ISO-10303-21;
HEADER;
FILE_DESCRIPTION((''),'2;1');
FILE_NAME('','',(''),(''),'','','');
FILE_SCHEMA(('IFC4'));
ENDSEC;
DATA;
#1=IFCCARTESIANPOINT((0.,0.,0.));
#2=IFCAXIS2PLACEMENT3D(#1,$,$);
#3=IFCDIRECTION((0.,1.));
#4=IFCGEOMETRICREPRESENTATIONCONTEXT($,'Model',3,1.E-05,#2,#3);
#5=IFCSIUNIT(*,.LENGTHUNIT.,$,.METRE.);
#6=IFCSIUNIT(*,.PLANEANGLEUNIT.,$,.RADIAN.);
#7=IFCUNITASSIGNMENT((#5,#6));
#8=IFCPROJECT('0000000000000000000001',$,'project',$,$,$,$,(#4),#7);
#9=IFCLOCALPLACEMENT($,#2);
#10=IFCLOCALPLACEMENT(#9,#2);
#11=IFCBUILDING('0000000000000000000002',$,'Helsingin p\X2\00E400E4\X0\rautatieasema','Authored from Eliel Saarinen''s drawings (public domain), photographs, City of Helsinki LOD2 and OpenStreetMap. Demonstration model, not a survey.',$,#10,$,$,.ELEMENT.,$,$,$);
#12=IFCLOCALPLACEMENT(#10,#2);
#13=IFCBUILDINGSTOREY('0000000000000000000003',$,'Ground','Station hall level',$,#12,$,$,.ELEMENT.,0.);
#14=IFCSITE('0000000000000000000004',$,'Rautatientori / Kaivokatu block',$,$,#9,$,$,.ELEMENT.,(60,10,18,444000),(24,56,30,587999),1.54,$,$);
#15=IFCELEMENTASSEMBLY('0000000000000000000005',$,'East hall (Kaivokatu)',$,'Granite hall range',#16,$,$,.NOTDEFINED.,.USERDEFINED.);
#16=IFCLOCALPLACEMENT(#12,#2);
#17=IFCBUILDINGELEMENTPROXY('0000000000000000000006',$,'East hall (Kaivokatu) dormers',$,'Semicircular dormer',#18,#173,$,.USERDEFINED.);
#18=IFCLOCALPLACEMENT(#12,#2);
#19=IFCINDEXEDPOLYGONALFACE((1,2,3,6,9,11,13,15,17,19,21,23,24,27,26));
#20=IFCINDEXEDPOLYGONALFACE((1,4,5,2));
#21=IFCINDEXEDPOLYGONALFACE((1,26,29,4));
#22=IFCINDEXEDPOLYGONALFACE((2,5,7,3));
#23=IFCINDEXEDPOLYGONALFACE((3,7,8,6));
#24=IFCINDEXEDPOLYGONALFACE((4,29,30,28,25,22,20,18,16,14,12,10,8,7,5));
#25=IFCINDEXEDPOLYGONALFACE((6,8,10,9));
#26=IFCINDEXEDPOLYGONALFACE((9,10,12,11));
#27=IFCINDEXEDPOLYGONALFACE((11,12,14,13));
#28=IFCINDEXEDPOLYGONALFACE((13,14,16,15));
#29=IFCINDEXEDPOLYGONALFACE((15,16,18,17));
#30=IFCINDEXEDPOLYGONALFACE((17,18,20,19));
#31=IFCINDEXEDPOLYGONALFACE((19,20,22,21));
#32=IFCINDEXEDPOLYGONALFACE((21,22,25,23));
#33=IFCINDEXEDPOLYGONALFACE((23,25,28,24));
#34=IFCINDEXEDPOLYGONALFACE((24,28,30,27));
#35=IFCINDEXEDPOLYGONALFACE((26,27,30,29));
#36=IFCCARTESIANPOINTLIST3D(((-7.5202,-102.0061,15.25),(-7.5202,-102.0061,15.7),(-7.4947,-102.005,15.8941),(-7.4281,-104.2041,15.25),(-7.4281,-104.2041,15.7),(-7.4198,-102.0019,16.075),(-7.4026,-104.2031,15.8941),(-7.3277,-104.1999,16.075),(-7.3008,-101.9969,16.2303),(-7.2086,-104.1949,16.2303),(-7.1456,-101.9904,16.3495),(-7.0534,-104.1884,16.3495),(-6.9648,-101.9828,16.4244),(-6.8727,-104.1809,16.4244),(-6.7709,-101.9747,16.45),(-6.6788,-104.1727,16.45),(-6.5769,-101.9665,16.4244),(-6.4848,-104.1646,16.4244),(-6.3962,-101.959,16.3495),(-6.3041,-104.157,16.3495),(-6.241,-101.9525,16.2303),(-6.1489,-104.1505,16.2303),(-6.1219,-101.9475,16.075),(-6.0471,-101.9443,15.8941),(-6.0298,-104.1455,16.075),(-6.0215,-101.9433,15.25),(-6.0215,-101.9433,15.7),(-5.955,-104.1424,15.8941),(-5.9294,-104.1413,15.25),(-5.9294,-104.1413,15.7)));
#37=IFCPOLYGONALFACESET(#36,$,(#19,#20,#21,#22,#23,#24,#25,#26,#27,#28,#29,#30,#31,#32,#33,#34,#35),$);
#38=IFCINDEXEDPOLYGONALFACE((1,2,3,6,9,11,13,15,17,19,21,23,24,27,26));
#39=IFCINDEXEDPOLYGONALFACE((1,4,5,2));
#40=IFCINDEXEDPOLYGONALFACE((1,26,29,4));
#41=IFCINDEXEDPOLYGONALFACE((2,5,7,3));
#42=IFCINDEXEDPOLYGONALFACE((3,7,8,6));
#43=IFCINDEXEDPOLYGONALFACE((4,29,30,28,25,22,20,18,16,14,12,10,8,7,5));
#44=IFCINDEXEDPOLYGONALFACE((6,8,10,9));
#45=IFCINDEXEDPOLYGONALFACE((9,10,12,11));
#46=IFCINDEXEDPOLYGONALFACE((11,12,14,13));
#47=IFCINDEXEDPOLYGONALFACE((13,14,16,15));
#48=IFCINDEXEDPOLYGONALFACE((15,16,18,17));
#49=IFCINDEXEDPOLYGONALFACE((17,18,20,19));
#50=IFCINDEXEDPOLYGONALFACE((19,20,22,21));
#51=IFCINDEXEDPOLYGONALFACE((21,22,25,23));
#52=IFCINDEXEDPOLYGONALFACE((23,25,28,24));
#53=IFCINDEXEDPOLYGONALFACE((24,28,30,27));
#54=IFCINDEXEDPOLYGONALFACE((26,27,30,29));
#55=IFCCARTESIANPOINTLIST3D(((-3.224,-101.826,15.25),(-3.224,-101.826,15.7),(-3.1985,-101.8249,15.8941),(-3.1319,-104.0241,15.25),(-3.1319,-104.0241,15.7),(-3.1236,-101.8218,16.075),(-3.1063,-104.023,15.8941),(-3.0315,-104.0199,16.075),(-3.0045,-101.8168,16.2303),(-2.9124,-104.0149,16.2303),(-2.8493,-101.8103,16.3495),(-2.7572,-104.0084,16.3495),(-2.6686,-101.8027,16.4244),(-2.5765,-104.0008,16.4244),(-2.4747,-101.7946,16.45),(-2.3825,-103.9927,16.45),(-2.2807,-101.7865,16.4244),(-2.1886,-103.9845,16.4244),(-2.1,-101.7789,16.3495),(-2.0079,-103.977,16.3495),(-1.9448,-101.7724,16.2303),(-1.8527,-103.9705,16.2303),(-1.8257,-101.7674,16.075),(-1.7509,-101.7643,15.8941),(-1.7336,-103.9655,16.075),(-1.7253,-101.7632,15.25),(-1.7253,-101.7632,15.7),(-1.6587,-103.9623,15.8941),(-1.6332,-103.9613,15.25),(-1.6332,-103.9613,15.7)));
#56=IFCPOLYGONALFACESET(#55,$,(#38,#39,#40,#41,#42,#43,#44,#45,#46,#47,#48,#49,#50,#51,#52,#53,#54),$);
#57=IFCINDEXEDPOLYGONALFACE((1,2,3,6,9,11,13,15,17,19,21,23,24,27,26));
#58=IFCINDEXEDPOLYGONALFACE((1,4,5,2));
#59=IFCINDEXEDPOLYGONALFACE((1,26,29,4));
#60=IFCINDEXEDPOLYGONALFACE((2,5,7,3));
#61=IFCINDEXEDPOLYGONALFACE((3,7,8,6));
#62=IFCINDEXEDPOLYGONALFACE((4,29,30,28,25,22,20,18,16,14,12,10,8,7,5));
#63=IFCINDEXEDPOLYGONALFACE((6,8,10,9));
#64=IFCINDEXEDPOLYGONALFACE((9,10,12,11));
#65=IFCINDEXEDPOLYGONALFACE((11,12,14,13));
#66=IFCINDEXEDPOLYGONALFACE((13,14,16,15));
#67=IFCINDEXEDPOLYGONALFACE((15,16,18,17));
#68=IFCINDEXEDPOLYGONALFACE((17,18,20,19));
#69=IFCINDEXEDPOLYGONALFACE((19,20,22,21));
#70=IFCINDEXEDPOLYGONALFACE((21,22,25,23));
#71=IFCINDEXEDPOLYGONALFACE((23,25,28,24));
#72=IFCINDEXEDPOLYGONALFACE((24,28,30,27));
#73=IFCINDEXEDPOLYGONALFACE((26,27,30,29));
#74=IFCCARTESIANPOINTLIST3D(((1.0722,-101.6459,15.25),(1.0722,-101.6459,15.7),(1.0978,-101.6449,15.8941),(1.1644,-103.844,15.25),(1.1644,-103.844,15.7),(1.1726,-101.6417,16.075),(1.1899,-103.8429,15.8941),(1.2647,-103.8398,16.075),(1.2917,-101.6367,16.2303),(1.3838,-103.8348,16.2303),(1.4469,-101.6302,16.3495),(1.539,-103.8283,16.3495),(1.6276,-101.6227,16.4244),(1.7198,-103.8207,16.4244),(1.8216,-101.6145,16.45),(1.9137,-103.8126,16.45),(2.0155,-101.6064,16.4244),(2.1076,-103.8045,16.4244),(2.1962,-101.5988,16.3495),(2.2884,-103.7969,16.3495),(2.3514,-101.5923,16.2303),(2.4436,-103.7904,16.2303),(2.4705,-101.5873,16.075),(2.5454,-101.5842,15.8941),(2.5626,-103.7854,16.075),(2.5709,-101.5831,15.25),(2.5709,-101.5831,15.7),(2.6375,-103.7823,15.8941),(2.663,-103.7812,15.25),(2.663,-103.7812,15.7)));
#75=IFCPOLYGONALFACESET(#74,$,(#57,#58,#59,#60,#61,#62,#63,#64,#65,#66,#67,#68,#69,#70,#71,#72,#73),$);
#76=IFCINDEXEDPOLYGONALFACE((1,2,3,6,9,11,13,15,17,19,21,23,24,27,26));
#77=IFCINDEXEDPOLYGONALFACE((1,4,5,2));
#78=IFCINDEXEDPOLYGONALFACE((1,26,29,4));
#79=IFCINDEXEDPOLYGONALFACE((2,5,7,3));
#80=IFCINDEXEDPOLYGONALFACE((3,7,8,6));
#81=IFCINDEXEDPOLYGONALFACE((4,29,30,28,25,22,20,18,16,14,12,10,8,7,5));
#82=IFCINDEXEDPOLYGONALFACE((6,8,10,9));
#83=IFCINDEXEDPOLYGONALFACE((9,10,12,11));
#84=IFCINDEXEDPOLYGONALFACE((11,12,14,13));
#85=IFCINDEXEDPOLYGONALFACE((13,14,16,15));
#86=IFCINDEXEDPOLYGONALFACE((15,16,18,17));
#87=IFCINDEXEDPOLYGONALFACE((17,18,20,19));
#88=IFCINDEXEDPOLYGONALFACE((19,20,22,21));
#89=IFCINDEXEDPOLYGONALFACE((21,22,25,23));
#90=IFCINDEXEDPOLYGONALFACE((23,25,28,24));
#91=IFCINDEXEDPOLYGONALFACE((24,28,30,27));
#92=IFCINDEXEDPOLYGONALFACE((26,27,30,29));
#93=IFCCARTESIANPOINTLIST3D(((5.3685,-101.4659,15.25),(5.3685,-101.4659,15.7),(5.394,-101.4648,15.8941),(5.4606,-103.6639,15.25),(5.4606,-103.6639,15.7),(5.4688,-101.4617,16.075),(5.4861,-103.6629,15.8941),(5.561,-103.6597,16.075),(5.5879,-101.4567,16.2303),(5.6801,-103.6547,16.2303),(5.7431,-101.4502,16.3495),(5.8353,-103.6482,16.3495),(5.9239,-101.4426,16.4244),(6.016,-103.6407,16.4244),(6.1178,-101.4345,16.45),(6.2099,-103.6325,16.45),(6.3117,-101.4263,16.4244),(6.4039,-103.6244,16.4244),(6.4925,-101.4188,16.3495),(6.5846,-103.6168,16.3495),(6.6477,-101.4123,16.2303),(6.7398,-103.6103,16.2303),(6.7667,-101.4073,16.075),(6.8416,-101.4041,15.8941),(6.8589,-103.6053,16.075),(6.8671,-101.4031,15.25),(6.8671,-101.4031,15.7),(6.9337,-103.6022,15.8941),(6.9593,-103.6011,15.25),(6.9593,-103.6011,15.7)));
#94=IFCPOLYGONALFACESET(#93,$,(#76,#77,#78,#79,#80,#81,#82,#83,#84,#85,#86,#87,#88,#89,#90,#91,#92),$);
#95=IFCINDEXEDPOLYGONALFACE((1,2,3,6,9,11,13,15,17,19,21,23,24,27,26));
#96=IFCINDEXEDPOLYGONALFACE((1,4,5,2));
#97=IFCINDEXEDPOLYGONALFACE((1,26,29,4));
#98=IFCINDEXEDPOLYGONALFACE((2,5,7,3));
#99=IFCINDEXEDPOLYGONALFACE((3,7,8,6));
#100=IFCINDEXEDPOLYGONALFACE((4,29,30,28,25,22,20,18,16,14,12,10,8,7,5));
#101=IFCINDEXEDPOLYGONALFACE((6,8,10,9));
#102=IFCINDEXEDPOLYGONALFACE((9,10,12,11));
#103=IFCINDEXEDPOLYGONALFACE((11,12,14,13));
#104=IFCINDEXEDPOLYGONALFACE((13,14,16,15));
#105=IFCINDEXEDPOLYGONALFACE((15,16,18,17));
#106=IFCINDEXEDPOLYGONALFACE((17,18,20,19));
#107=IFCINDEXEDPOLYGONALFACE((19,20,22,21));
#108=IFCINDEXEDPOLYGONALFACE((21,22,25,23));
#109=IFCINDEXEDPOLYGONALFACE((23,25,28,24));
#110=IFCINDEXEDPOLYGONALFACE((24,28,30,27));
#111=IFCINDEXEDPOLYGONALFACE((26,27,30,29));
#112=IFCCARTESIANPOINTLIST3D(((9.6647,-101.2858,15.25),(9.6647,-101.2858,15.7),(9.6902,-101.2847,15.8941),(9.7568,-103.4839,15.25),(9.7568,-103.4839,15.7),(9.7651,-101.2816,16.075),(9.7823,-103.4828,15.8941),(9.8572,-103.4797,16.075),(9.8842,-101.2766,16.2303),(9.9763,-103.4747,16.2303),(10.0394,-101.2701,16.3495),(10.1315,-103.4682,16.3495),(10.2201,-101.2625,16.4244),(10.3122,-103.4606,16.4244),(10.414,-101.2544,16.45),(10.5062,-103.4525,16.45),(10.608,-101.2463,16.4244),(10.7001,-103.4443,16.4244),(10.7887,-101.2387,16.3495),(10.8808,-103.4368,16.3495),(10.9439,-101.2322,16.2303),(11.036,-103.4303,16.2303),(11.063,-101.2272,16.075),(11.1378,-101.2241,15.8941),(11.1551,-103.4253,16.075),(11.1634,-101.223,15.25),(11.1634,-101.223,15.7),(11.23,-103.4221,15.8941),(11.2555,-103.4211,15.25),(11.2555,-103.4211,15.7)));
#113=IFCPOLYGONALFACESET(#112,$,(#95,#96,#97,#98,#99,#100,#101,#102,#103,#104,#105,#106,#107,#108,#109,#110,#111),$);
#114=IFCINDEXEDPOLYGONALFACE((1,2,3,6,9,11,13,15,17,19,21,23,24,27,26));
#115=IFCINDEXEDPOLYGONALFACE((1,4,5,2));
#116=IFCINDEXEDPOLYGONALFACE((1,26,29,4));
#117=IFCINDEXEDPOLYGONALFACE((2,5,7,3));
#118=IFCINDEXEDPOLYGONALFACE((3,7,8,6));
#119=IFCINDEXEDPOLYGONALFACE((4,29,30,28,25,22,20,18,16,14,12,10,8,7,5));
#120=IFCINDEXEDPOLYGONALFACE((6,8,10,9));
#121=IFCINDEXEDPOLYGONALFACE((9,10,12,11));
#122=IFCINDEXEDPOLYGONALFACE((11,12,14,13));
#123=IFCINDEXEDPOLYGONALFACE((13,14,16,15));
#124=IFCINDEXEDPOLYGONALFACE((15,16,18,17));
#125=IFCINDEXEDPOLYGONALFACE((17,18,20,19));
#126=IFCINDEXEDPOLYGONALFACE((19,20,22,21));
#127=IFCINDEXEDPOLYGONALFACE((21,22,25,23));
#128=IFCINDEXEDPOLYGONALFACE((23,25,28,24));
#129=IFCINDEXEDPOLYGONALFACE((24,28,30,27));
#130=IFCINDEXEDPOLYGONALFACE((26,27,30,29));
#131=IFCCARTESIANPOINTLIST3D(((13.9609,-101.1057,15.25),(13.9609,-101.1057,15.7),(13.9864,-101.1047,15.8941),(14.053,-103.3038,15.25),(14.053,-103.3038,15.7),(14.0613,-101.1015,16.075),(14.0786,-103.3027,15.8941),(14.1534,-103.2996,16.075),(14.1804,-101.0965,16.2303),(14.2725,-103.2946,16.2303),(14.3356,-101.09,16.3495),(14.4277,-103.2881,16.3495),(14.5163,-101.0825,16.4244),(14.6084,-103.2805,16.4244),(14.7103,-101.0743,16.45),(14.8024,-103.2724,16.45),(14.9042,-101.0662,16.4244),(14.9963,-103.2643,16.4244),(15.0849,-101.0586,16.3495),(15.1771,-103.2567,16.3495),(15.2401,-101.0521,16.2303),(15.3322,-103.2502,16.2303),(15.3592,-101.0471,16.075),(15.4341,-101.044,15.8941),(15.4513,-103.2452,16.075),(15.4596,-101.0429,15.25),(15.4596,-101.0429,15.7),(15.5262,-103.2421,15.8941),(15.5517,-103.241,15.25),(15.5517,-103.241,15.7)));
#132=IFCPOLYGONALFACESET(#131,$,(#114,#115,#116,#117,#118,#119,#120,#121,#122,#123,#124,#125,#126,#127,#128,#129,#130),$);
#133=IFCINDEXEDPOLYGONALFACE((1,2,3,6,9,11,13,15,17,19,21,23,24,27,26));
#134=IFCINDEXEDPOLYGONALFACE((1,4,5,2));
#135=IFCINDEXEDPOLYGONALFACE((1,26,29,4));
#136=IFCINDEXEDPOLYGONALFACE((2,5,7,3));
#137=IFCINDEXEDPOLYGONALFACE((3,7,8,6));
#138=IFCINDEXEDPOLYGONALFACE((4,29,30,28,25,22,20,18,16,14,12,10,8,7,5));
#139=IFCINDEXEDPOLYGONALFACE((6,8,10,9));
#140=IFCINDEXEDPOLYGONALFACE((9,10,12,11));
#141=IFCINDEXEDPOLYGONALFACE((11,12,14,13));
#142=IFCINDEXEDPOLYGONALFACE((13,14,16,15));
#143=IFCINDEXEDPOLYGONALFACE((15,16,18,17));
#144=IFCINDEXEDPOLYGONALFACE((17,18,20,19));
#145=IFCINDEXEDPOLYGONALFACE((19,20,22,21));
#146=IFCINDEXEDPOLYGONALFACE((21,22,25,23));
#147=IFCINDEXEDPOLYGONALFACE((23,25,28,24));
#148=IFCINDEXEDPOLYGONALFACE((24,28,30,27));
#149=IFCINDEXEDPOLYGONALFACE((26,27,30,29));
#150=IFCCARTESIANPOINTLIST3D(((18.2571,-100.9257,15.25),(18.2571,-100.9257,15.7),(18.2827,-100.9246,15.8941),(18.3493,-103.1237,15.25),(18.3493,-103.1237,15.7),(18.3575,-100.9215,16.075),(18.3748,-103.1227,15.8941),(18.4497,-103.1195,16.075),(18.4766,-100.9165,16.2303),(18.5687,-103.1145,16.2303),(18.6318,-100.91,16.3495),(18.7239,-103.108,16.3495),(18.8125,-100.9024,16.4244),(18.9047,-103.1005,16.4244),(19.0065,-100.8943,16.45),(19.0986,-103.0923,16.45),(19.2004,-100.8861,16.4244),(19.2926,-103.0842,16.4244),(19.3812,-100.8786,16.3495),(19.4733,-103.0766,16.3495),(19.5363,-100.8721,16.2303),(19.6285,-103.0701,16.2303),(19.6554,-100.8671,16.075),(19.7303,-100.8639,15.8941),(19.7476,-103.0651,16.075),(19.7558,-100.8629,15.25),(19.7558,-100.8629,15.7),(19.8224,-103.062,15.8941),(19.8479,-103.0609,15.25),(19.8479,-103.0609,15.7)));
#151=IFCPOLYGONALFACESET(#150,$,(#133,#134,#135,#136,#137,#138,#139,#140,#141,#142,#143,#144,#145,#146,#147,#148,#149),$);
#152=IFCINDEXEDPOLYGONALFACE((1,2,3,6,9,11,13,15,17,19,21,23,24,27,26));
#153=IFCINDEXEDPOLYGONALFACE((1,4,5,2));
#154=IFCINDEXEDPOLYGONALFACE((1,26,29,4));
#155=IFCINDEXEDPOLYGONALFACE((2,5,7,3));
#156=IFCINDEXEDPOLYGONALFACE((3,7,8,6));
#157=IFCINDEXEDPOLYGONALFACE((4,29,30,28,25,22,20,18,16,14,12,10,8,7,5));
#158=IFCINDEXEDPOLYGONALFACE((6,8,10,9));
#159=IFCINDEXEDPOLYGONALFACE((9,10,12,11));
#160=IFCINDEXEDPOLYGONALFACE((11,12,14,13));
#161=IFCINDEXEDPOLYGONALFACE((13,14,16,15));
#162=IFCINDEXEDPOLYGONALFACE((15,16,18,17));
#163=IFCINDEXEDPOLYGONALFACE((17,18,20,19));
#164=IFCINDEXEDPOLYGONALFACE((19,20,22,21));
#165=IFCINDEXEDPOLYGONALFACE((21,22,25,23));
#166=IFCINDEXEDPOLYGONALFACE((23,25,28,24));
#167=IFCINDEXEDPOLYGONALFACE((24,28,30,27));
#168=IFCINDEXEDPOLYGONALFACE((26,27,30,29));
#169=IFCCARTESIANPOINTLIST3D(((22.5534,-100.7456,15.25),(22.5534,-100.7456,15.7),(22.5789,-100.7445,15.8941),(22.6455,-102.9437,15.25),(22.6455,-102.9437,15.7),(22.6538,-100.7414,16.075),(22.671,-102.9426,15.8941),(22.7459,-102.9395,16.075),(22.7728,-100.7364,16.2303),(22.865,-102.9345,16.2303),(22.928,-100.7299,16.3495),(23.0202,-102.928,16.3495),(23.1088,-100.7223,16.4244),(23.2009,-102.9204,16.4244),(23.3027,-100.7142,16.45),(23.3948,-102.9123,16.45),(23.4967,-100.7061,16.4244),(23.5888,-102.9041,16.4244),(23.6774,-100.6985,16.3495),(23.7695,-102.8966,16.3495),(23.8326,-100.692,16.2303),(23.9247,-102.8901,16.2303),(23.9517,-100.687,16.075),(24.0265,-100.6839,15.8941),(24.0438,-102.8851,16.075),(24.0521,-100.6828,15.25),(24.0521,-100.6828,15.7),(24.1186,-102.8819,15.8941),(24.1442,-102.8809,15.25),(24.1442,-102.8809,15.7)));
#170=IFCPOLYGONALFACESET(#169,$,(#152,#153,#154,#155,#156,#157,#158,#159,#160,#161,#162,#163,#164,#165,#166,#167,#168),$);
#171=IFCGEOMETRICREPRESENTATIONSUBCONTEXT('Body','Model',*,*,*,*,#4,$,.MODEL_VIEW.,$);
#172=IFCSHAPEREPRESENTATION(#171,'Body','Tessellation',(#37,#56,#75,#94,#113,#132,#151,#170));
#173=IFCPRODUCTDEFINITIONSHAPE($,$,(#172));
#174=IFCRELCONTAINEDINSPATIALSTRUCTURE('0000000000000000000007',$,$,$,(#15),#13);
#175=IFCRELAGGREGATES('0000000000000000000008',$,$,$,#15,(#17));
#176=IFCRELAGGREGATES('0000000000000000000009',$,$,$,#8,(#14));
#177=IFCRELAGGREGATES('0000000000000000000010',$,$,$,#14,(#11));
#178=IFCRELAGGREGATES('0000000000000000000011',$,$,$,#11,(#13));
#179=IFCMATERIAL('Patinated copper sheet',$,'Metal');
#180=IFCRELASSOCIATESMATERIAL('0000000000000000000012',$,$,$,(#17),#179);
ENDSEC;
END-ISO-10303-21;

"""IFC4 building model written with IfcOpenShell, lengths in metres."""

from ifc_helpers import new_model, si_unit, direction, frame, origin, place, context, subcontext, project, spatial, polyline, outline, extrude, material, element, aggregate, save


model = new_model("IFC4")

# Units and contexts
model_context = context("Model", 3, precision=1e-05, world=origin(), true_north=direction((0.0, 1.0)))
body_context = subcontext(model_context, "Body", "Model", "MODEL_VIEW")
ifc_project = project(units=[si_unit("LENGTHUNIT", "METRE"), si_unit("PLANEANGLEUNIT", "RADIAN")], contexts=[model_context])

# Site, building, storey
site_placement = place(None, origin())
site = spatial("IfcSite", under=ifc_project, at=site_placement, Name="Rautatientori / Kaivokatu block", CompositionType="ELEMENT", RefLatitude=(60, 10, 18, 444000), RefLongitude=(24, 56, 30, 587999), RefElevation=1.54)
building_placement = place(site_placement, origin())
building = spatial("IfcBuilding", under=site, at=building_placement, Name="Helsingin päärautatieasema", Description="Authored from Eliel Saarinen's drawings (public domain), photographs, City of Helsinki LOD2 and OpenStreetMap. Demonstration model, not a survey.", CompositionType="ELEMENT")
storey_placement = place(building_placement, origin())
storey = spatial("IfcBuildingStorey", under=building, at=storey_placement, Name="Ground", Description="Station hall level", CompositionType="ELEMENT", Elevation=0.0)

# Element assembly
assembly_1_placement = place(building_placement, origin())
assembly_1 = element("IfcElementAssembly", 1, at=assembly_1_placement, inside=storey, Name="East hall (Kaivokatu)", ObjectType="Granite hall range", AssemblyPlace="NOTDEFINED", PredefinedType="USERDEFINED")

# Shared definitions
ifc_material_1 = material(Name="Patinated copper sheet", Category="Metal")

# Building element proxy
proxy_1_placement = place(building_placement, origin())
proxy_1 = element("IfcBuildingElementProxy", 2, at=proxy_1_placement, material=ifc_material_1, Name="East hall (Kaivokatu) dormers", ObjectType="Semicircular dormer", PredefinedType="USERDEFINED", context=body_context, shape_type="SweptSolid", body=[
    extrude(outline(polyline([(-0.75, 0.0), (0.75, 0.0), (0.75, 0.45), (0.7244, 0.6441), (0.6495, 0.825), (0.5303, 0.9803), (0.375, 1.0995), (0.1941, 1.1744), (0.0, 1.2), (-0.1941, 1.1744), (-0.375, 1.0995), (-0.5303, 0.9803), (-0.6495, 0.825), (-0.7244, 0.6441), (-0.75, 0.45), (-0.75, 0.0)])), frame((-6.7709, -101.9747, 15.25), z_axis=(0.041876, -0.999123, 0.0), x_axis=(0.999123, 0.041876, 0.0)), (0.0, 0.0, 1.0), 2.2),
    extrude(outline(polyline([(-0.75, 0.0), (0.75, 0.0), (0.75, 0.45), (0.7244, 0.6441), (0.6495, 0.825), (0.5303, 0.9803), (0.375, 1.0995), (0.1941, 1.1744), (0.0, 1.2), (-0.1941, 1.1744), (-0.375, 1.0995), (-0.5303, 0.9803), (-0.6495, 0.825), (-0.7244, 0.6441), (-0.75, 0.45), (-0.75, 0.0)])), frame((-2.4747, -101.7946, 15.25), z_axis=(0.041876, -0.999123, 0.0), x_axis=(0.999123, 0.041876, 0.0)), (0.0, 0.0, 1.0), 2.2),
    extrude(outline(polyline([(-0.75, 0.0), (0.75, 0.0), (0.75, 0.45), (0.7244, 0.6441), (0.6495, 0.825), (0.5303, 0.9803), (0.375, 1.0995), (0.1941, 1.1744), (0.0, 1.2), (-0.1941, 1.1744), (-0.375, 1.0995), (-0.5303, 0.9803), (-0.6495, 0.825), (-0.7244, 0.6441), (-0.75, 0.45), (-0.75, 0.0)])), frame((1.8216, -101.6145, 15.25), z_axis=(0.041876, -0.999123, 0.0), x_axis=(0.999123, 0.041876, 0.0)), (0.0, 0.0, 1.0), 2.2),
    extrude(outline(polyline([(-0.75, 0.0), (0.75, 0.0), (0.75, 0.45), (0.7244, 0.6441), (0.6495, 0.825), (0.5303, 0.9803), (0.375, 1.0995), (0.1941, 1.1744), (0.0, 1.2), (-0.1941, 1.1744), (-0.375, 1.0995), (-0.5303, 0.9803), (-0.6495, 0.825), (-0.7244, 0.6441), (-0.75, 0.45), (-0.75, 0.0)])), frame((6.1178, -101.4345, 15.25), z_axis=(0.041876, -0.999123, 0.0), x_axis=(0.999123, 0.041876, 0.0)), (0.0, 0.0, 1.0), 2.2),
    extrude(outline(polyline([(-0.75, 0.0), (0.75, 0.0), (0.75, 0.45), (0.7244, 0.6441), (0.6495, 0.825), (0.5303, 0.9803), (0.375, 1.0995), (0.1941, 1.1744), (0.0, 1.2), (-0.1941, 1.1744), (-0.375, 1.0995), (-0.5303, 0.9803), (-0.6495, 0.825), (-0.7244, 0.6441), (-0.75, 0.45), (-0.75, 0.0)])), frame((10.414, -101.2544, 15.25), z_axis=(0.041876, -0.999123, 0.0), x_axis=(0.999123, 0.041876, 0.0)), (0.0, 0.0, 1.0), 2.2),
    extrude(outline(polyline([(-0.75, 0.0), (0.75, 0.0), (0.75, 0.45), (0.7244, 0.6441), (0.6495, 0.825), (0.5303, 0.9803), (0.375, 1.0995), (0.1941, 1.1744), (0.0, 1.2), (-0.1941, 1.1744), (-0.375, 1.0995), (-0.5303, 0.9803), (-0.6495, 0.825), (-0.7244, 0.6441), (-0.75, 0.45), (-0.75, 0.0)])), frame((14.7103, -101.0743, 15.25), z_axis=(0.041876, -0.999123, 0.0), x_axis=(0.999123, 0.041876, 0.0)), (0.0, 0.0, 1.0), 2.2),
    extrude(outline(polyline([(-0.75, 0.0), (0.75, 0.0), (0.75, 0.45), (0.7244, 0.6441), (0.6495, 0.825), (0.5303, 0.9803), (0.375, 1.0995), (0.1941, 1.1744), (0.0, 1.2), (-0.1941, 1.1744), (-0.375, 1.0995), (-0.5303, 0.9803), (-0.6495, 0.825), (-0.7244, 0.6441), (-0.75, 0.45), (-0.75, 0.0)])), frame((19.0065, -100.8943, 15.25), z_axis=(0.041876, -0.999123, 0.0), x_axis=(0.999123, 0.041876, 0.0)), (0.0, 0.0, 1.0), 2.2),
    extrude(outline(polyline([(-0.75, 0.0), (0.75, 0.0), (0.75, 0.45), (0.7244, 0.6441), (0.6495, 0.825), (0.5303, 0.9803), (0.375, 1.0995), (0.1941, 1.1744), (0.0, 1.2), (-0.1941, 1.1744), (-0.375, 1.0995), (-0.5303, 0.9803), (-0.6495, 0.825), (-0.7244, 0.6441), (-0.75, 0.45), (-0.75, 0.0)])), frame((23.3027, -100.7142, 15.25), z_axis=(0.041876, -0.999123, 0.0), x_axis=(0.999123, 0.041876, 0.0)), (0.0, 0.0, 1.0), 2.2),
])
aggregate(assembly_1, [proxy_1])

save(model, "model.ifc")
